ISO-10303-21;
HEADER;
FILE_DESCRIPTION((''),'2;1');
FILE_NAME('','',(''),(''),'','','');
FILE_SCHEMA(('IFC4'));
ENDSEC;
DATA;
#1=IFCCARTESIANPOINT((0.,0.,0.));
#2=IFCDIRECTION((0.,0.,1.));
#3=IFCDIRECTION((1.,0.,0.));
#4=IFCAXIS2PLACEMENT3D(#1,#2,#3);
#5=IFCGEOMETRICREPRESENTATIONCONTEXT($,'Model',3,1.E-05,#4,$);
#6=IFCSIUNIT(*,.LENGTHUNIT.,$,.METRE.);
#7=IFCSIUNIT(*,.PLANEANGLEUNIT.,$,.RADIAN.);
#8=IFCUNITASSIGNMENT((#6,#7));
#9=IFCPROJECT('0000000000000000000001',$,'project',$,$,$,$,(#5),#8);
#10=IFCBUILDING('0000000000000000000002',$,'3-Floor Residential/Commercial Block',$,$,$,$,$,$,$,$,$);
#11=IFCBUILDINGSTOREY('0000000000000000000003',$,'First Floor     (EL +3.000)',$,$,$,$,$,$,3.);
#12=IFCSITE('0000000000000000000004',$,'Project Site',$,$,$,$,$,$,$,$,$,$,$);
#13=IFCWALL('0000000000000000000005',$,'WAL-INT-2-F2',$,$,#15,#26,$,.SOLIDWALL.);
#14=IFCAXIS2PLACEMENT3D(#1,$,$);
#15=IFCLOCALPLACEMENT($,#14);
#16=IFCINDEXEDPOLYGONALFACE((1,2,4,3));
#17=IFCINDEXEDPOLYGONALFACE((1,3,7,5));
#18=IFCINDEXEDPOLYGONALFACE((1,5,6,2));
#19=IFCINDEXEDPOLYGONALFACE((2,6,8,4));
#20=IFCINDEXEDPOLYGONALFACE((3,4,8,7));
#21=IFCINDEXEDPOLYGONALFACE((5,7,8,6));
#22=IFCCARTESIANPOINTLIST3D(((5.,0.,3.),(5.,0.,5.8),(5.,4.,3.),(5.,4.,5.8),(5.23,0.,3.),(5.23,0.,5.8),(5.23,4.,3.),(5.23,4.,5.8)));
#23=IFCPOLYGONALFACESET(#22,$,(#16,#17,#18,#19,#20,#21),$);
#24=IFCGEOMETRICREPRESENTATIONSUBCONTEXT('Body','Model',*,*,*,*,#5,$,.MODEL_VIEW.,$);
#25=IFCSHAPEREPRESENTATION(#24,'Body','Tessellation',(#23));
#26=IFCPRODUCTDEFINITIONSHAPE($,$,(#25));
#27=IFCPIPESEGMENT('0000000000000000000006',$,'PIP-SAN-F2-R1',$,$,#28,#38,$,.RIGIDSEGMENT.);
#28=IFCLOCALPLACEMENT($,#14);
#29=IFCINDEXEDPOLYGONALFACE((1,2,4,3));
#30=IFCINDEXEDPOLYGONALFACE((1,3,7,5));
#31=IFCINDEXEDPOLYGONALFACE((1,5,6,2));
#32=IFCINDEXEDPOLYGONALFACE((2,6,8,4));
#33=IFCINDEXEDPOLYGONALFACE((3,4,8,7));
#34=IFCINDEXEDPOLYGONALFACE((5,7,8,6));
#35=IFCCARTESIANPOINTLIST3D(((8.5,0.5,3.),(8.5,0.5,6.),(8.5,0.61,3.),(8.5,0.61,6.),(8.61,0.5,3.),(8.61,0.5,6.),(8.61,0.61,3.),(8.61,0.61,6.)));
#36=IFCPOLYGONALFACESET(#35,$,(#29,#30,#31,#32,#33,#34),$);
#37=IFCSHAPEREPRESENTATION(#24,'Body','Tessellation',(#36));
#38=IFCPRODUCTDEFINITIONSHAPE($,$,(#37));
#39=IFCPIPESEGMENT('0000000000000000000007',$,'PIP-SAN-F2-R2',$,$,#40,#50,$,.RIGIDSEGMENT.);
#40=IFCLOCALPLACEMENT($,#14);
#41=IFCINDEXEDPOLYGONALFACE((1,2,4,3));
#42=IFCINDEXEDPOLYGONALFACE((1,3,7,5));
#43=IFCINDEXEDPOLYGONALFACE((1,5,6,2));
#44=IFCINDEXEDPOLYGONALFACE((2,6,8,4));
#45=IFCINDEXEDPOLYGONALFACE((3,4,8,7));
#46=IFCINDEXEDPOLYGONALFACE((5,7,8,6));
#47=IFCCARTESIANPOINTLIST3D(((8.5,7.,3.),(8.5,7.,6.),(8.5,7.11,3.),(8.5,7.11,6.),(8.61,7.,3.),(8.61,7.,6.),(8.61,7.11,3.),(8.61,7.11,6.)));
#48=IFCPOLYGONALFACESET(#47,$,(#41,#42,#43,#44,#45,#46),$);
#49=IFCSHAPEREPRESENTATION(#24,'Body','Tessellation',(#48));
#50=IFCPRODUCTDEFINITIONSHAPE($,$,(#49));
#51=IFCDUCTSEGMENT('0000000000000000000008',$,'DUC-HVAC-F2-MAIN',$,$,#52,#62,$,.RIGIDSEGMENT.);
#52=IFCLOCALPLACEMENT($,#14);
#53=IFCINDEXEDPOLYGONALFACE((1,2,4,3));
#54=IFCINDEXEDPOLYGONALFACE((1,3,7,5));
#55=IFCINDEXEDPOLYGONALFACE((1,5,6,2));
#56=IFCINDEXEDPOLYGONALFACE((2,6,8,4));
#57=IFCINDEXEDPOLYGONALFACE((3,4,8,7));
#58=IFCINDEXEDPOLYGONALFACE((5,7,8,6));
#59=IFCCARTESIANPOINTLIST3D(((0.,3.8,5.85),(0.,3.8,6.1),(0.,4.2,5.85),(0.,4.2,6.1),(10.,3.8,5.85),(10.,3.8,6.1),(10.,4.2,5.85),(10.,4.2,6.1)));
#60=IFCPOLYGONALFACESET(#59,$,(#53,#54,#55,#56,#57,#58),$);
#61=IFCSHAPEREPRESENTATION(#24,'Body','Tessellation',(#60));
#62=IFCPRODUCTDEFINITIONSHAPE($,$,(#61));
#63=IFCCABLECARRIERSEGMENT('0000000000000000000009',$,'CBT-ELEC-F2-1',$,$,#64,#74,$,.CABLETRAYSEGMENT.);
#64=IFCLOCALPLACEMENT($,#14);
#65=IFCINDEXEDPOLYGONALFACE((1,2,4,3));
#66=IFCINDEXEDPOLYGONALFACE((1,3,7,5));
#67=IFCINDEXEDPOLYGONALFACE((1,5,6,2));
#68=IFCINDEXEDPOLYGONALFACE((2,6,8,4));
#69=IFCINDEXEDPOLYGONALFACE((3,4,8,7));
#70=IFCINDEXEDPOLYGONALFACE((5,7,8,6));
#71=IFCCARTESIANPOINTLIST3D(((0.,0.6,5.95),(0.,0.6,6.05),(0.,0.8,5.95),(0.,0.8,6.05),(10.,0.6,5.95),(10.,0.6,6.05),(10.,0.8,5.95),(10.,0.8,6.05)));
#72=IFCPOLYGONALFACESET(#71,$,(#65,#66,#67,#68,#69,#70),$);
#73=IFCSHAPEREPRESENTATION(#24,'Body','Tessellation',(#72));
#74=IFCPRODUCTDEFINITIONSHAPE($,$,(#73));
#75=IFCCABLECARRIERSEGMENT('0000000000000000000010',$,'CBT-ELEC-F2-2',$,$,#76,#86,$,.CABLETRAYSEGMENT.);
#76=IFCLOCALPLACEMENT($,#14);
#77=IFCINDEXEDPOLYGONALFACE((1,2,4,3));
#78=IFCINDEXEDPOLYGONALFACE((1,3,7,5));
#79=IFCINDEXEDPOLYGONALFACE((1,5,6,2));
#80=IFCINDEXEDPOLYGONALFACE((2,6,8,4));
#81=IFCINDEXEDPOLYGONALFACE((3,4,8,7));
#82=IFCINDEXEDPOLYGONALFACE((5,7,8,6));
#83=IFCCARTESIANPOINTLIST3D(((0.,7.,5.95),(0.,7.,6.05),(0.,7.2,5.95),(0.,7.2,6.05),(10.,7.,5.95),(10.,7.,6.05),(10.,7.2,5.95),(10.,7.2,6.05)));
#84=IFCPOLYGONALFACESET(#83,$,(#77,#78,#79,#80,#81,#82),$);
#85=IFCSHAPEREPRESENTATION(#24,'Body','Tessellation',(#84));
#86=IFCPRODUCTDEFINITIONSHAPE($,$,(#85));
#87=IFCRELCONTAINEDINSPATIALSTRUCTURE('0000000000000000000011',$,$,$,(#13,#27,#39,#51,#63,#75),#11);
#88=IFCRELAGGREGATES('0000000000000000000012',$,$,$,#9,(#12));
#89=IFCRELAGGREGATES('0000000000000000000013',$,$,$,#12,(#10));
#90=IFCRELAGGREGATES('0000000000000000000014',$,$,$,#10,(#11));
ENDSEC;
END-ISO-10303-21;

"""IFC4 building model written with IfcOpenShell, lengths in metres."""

from ifc_helpers import new_model, si_unit, frame, frame_2d, origin_with_axes, place, context, subcontext, project, spatial, rectangle, extrude, element, save


model = new_model("IFC4")

# Units and contexts
model_context = context("Model", 3, precision=1e-05, world=origin_with_axes())
body_context = subcontext(model_context, "Body", "Model", "MODEL_VIEW")
ifc_project = project(units=[si_unit("LENGTHUNIT", "METRE"), si_unit("PLANEANGLEUNIT", "RADIAN")], contexts=[model_context])

# Site, building, storey
site = spatial("IfcSite", under=ifc_project, Name="Project Site")
building = spatial("IfcBuilding", under=site, Name="3-Floor Residential/Commercial Block")
storey = spatial("IfcBuildingStorey", under=building, Name="First Floor     (EL +3.000)", Elevation=3.0)

# Wall
wall_1_placement = place(None, frame((5.0, 0.0, 3.0), z_axis=(0.0, 0.0, 1.0), x_axis=(1.0, 0.0, 0.0)))
element("IfcWall", 1, at=wall_1_placement, inside=storey, Name="WAL-INT-2-F2", PredefinedType="SOLIDWALL", context=body_context, shape_type="SweptSolid", body=[
    extrude(rectangle(XDim=0.23, YDim=4.0, at=frame_2d((0.115, 2.0))), origin_with_axes(), (0.0, 0.0, 1.0), 2.8),
])

# Pipe segments
for number, where, z_axis, x_axis, name in (
    (2, (8.5, 0.5, 3.0), (0.0, 0.0, 1.0), (1.0, 0.0, 0.0), "PIP-SAN-F2-R1"),
    (3, (8.5, 7.0, 3.0), (0.0, 0.0, 1.0), (1.0, 0.0, 0.0), "PIP-SAN-F2-R2"),
):
    element("IfcPipeSegment", number, at=place(None, frame(where, z_axis=z_axis, x_axis=x_axis)), inside=storey, Name=name, PredefinedType="RIGIDSEGMENT", context=body_context, shape_type="SweptSolid", body=[
        extrude(rectangle(XDim=0.11, YDim=0.11, at=frame_2d((0.055, 0.055))), origin_with_axes(), (0.0, 0.0, 1.0), 3.0),
    ])

# Duct segment
duct_segment_placement = place(None, frame((0.0, 3.8, 5.85), z_axis=(0.0, 0.0, 1.0), x_axis=(1.0, 0.0, 0.0)))
element("IfcDuctSegment", 4, at=duct_segment_placement, inside=storey, Name="DUC-HVAC-F2-MAIN", PredefinedType="RIGIDSEGMENT", context=body_context, shape_type="SweptSolid", body=[
    extrude(rectangle(XDim=10.0, YDim=0.4, at=frame_2d((5.0, 0.2))), origin_with_axes(), (0.0, 0.0, 1.0), 0.25),
])

# Cable carrier segments
for number, where, z_axis, x_axis, name in (
    (5, (0.0, 0.6, 5.95), (0.0, 0.0, 1.0), (1.0, 0.0, 0.0), "CBT-ELEC-F2-1"),
    (6, (0.0, 7.0, 5.95), (0.0, 0.0, 1.0), (1.0, 0.0, 0.0), "CBT-ELEC-F2-2"),
):
    element("IfcCableCarrierSegment", number, at=place(None, frame(where, z_axis=z_axis, x_axis=x_axis)), inside=storey, Name=name, PredefinedType="CABLETRAYSEGMENT", context=body_context, shape_type="SweptSolid", body=[
        extrude(rectangle(XDim=10.0, YDim=0.2, at=frame_2d((5.0, 0.1))), origin_with_axes(), (0.0, 0.0, 1.0), 0.1),
    ])

save(model, "model.ifc")
